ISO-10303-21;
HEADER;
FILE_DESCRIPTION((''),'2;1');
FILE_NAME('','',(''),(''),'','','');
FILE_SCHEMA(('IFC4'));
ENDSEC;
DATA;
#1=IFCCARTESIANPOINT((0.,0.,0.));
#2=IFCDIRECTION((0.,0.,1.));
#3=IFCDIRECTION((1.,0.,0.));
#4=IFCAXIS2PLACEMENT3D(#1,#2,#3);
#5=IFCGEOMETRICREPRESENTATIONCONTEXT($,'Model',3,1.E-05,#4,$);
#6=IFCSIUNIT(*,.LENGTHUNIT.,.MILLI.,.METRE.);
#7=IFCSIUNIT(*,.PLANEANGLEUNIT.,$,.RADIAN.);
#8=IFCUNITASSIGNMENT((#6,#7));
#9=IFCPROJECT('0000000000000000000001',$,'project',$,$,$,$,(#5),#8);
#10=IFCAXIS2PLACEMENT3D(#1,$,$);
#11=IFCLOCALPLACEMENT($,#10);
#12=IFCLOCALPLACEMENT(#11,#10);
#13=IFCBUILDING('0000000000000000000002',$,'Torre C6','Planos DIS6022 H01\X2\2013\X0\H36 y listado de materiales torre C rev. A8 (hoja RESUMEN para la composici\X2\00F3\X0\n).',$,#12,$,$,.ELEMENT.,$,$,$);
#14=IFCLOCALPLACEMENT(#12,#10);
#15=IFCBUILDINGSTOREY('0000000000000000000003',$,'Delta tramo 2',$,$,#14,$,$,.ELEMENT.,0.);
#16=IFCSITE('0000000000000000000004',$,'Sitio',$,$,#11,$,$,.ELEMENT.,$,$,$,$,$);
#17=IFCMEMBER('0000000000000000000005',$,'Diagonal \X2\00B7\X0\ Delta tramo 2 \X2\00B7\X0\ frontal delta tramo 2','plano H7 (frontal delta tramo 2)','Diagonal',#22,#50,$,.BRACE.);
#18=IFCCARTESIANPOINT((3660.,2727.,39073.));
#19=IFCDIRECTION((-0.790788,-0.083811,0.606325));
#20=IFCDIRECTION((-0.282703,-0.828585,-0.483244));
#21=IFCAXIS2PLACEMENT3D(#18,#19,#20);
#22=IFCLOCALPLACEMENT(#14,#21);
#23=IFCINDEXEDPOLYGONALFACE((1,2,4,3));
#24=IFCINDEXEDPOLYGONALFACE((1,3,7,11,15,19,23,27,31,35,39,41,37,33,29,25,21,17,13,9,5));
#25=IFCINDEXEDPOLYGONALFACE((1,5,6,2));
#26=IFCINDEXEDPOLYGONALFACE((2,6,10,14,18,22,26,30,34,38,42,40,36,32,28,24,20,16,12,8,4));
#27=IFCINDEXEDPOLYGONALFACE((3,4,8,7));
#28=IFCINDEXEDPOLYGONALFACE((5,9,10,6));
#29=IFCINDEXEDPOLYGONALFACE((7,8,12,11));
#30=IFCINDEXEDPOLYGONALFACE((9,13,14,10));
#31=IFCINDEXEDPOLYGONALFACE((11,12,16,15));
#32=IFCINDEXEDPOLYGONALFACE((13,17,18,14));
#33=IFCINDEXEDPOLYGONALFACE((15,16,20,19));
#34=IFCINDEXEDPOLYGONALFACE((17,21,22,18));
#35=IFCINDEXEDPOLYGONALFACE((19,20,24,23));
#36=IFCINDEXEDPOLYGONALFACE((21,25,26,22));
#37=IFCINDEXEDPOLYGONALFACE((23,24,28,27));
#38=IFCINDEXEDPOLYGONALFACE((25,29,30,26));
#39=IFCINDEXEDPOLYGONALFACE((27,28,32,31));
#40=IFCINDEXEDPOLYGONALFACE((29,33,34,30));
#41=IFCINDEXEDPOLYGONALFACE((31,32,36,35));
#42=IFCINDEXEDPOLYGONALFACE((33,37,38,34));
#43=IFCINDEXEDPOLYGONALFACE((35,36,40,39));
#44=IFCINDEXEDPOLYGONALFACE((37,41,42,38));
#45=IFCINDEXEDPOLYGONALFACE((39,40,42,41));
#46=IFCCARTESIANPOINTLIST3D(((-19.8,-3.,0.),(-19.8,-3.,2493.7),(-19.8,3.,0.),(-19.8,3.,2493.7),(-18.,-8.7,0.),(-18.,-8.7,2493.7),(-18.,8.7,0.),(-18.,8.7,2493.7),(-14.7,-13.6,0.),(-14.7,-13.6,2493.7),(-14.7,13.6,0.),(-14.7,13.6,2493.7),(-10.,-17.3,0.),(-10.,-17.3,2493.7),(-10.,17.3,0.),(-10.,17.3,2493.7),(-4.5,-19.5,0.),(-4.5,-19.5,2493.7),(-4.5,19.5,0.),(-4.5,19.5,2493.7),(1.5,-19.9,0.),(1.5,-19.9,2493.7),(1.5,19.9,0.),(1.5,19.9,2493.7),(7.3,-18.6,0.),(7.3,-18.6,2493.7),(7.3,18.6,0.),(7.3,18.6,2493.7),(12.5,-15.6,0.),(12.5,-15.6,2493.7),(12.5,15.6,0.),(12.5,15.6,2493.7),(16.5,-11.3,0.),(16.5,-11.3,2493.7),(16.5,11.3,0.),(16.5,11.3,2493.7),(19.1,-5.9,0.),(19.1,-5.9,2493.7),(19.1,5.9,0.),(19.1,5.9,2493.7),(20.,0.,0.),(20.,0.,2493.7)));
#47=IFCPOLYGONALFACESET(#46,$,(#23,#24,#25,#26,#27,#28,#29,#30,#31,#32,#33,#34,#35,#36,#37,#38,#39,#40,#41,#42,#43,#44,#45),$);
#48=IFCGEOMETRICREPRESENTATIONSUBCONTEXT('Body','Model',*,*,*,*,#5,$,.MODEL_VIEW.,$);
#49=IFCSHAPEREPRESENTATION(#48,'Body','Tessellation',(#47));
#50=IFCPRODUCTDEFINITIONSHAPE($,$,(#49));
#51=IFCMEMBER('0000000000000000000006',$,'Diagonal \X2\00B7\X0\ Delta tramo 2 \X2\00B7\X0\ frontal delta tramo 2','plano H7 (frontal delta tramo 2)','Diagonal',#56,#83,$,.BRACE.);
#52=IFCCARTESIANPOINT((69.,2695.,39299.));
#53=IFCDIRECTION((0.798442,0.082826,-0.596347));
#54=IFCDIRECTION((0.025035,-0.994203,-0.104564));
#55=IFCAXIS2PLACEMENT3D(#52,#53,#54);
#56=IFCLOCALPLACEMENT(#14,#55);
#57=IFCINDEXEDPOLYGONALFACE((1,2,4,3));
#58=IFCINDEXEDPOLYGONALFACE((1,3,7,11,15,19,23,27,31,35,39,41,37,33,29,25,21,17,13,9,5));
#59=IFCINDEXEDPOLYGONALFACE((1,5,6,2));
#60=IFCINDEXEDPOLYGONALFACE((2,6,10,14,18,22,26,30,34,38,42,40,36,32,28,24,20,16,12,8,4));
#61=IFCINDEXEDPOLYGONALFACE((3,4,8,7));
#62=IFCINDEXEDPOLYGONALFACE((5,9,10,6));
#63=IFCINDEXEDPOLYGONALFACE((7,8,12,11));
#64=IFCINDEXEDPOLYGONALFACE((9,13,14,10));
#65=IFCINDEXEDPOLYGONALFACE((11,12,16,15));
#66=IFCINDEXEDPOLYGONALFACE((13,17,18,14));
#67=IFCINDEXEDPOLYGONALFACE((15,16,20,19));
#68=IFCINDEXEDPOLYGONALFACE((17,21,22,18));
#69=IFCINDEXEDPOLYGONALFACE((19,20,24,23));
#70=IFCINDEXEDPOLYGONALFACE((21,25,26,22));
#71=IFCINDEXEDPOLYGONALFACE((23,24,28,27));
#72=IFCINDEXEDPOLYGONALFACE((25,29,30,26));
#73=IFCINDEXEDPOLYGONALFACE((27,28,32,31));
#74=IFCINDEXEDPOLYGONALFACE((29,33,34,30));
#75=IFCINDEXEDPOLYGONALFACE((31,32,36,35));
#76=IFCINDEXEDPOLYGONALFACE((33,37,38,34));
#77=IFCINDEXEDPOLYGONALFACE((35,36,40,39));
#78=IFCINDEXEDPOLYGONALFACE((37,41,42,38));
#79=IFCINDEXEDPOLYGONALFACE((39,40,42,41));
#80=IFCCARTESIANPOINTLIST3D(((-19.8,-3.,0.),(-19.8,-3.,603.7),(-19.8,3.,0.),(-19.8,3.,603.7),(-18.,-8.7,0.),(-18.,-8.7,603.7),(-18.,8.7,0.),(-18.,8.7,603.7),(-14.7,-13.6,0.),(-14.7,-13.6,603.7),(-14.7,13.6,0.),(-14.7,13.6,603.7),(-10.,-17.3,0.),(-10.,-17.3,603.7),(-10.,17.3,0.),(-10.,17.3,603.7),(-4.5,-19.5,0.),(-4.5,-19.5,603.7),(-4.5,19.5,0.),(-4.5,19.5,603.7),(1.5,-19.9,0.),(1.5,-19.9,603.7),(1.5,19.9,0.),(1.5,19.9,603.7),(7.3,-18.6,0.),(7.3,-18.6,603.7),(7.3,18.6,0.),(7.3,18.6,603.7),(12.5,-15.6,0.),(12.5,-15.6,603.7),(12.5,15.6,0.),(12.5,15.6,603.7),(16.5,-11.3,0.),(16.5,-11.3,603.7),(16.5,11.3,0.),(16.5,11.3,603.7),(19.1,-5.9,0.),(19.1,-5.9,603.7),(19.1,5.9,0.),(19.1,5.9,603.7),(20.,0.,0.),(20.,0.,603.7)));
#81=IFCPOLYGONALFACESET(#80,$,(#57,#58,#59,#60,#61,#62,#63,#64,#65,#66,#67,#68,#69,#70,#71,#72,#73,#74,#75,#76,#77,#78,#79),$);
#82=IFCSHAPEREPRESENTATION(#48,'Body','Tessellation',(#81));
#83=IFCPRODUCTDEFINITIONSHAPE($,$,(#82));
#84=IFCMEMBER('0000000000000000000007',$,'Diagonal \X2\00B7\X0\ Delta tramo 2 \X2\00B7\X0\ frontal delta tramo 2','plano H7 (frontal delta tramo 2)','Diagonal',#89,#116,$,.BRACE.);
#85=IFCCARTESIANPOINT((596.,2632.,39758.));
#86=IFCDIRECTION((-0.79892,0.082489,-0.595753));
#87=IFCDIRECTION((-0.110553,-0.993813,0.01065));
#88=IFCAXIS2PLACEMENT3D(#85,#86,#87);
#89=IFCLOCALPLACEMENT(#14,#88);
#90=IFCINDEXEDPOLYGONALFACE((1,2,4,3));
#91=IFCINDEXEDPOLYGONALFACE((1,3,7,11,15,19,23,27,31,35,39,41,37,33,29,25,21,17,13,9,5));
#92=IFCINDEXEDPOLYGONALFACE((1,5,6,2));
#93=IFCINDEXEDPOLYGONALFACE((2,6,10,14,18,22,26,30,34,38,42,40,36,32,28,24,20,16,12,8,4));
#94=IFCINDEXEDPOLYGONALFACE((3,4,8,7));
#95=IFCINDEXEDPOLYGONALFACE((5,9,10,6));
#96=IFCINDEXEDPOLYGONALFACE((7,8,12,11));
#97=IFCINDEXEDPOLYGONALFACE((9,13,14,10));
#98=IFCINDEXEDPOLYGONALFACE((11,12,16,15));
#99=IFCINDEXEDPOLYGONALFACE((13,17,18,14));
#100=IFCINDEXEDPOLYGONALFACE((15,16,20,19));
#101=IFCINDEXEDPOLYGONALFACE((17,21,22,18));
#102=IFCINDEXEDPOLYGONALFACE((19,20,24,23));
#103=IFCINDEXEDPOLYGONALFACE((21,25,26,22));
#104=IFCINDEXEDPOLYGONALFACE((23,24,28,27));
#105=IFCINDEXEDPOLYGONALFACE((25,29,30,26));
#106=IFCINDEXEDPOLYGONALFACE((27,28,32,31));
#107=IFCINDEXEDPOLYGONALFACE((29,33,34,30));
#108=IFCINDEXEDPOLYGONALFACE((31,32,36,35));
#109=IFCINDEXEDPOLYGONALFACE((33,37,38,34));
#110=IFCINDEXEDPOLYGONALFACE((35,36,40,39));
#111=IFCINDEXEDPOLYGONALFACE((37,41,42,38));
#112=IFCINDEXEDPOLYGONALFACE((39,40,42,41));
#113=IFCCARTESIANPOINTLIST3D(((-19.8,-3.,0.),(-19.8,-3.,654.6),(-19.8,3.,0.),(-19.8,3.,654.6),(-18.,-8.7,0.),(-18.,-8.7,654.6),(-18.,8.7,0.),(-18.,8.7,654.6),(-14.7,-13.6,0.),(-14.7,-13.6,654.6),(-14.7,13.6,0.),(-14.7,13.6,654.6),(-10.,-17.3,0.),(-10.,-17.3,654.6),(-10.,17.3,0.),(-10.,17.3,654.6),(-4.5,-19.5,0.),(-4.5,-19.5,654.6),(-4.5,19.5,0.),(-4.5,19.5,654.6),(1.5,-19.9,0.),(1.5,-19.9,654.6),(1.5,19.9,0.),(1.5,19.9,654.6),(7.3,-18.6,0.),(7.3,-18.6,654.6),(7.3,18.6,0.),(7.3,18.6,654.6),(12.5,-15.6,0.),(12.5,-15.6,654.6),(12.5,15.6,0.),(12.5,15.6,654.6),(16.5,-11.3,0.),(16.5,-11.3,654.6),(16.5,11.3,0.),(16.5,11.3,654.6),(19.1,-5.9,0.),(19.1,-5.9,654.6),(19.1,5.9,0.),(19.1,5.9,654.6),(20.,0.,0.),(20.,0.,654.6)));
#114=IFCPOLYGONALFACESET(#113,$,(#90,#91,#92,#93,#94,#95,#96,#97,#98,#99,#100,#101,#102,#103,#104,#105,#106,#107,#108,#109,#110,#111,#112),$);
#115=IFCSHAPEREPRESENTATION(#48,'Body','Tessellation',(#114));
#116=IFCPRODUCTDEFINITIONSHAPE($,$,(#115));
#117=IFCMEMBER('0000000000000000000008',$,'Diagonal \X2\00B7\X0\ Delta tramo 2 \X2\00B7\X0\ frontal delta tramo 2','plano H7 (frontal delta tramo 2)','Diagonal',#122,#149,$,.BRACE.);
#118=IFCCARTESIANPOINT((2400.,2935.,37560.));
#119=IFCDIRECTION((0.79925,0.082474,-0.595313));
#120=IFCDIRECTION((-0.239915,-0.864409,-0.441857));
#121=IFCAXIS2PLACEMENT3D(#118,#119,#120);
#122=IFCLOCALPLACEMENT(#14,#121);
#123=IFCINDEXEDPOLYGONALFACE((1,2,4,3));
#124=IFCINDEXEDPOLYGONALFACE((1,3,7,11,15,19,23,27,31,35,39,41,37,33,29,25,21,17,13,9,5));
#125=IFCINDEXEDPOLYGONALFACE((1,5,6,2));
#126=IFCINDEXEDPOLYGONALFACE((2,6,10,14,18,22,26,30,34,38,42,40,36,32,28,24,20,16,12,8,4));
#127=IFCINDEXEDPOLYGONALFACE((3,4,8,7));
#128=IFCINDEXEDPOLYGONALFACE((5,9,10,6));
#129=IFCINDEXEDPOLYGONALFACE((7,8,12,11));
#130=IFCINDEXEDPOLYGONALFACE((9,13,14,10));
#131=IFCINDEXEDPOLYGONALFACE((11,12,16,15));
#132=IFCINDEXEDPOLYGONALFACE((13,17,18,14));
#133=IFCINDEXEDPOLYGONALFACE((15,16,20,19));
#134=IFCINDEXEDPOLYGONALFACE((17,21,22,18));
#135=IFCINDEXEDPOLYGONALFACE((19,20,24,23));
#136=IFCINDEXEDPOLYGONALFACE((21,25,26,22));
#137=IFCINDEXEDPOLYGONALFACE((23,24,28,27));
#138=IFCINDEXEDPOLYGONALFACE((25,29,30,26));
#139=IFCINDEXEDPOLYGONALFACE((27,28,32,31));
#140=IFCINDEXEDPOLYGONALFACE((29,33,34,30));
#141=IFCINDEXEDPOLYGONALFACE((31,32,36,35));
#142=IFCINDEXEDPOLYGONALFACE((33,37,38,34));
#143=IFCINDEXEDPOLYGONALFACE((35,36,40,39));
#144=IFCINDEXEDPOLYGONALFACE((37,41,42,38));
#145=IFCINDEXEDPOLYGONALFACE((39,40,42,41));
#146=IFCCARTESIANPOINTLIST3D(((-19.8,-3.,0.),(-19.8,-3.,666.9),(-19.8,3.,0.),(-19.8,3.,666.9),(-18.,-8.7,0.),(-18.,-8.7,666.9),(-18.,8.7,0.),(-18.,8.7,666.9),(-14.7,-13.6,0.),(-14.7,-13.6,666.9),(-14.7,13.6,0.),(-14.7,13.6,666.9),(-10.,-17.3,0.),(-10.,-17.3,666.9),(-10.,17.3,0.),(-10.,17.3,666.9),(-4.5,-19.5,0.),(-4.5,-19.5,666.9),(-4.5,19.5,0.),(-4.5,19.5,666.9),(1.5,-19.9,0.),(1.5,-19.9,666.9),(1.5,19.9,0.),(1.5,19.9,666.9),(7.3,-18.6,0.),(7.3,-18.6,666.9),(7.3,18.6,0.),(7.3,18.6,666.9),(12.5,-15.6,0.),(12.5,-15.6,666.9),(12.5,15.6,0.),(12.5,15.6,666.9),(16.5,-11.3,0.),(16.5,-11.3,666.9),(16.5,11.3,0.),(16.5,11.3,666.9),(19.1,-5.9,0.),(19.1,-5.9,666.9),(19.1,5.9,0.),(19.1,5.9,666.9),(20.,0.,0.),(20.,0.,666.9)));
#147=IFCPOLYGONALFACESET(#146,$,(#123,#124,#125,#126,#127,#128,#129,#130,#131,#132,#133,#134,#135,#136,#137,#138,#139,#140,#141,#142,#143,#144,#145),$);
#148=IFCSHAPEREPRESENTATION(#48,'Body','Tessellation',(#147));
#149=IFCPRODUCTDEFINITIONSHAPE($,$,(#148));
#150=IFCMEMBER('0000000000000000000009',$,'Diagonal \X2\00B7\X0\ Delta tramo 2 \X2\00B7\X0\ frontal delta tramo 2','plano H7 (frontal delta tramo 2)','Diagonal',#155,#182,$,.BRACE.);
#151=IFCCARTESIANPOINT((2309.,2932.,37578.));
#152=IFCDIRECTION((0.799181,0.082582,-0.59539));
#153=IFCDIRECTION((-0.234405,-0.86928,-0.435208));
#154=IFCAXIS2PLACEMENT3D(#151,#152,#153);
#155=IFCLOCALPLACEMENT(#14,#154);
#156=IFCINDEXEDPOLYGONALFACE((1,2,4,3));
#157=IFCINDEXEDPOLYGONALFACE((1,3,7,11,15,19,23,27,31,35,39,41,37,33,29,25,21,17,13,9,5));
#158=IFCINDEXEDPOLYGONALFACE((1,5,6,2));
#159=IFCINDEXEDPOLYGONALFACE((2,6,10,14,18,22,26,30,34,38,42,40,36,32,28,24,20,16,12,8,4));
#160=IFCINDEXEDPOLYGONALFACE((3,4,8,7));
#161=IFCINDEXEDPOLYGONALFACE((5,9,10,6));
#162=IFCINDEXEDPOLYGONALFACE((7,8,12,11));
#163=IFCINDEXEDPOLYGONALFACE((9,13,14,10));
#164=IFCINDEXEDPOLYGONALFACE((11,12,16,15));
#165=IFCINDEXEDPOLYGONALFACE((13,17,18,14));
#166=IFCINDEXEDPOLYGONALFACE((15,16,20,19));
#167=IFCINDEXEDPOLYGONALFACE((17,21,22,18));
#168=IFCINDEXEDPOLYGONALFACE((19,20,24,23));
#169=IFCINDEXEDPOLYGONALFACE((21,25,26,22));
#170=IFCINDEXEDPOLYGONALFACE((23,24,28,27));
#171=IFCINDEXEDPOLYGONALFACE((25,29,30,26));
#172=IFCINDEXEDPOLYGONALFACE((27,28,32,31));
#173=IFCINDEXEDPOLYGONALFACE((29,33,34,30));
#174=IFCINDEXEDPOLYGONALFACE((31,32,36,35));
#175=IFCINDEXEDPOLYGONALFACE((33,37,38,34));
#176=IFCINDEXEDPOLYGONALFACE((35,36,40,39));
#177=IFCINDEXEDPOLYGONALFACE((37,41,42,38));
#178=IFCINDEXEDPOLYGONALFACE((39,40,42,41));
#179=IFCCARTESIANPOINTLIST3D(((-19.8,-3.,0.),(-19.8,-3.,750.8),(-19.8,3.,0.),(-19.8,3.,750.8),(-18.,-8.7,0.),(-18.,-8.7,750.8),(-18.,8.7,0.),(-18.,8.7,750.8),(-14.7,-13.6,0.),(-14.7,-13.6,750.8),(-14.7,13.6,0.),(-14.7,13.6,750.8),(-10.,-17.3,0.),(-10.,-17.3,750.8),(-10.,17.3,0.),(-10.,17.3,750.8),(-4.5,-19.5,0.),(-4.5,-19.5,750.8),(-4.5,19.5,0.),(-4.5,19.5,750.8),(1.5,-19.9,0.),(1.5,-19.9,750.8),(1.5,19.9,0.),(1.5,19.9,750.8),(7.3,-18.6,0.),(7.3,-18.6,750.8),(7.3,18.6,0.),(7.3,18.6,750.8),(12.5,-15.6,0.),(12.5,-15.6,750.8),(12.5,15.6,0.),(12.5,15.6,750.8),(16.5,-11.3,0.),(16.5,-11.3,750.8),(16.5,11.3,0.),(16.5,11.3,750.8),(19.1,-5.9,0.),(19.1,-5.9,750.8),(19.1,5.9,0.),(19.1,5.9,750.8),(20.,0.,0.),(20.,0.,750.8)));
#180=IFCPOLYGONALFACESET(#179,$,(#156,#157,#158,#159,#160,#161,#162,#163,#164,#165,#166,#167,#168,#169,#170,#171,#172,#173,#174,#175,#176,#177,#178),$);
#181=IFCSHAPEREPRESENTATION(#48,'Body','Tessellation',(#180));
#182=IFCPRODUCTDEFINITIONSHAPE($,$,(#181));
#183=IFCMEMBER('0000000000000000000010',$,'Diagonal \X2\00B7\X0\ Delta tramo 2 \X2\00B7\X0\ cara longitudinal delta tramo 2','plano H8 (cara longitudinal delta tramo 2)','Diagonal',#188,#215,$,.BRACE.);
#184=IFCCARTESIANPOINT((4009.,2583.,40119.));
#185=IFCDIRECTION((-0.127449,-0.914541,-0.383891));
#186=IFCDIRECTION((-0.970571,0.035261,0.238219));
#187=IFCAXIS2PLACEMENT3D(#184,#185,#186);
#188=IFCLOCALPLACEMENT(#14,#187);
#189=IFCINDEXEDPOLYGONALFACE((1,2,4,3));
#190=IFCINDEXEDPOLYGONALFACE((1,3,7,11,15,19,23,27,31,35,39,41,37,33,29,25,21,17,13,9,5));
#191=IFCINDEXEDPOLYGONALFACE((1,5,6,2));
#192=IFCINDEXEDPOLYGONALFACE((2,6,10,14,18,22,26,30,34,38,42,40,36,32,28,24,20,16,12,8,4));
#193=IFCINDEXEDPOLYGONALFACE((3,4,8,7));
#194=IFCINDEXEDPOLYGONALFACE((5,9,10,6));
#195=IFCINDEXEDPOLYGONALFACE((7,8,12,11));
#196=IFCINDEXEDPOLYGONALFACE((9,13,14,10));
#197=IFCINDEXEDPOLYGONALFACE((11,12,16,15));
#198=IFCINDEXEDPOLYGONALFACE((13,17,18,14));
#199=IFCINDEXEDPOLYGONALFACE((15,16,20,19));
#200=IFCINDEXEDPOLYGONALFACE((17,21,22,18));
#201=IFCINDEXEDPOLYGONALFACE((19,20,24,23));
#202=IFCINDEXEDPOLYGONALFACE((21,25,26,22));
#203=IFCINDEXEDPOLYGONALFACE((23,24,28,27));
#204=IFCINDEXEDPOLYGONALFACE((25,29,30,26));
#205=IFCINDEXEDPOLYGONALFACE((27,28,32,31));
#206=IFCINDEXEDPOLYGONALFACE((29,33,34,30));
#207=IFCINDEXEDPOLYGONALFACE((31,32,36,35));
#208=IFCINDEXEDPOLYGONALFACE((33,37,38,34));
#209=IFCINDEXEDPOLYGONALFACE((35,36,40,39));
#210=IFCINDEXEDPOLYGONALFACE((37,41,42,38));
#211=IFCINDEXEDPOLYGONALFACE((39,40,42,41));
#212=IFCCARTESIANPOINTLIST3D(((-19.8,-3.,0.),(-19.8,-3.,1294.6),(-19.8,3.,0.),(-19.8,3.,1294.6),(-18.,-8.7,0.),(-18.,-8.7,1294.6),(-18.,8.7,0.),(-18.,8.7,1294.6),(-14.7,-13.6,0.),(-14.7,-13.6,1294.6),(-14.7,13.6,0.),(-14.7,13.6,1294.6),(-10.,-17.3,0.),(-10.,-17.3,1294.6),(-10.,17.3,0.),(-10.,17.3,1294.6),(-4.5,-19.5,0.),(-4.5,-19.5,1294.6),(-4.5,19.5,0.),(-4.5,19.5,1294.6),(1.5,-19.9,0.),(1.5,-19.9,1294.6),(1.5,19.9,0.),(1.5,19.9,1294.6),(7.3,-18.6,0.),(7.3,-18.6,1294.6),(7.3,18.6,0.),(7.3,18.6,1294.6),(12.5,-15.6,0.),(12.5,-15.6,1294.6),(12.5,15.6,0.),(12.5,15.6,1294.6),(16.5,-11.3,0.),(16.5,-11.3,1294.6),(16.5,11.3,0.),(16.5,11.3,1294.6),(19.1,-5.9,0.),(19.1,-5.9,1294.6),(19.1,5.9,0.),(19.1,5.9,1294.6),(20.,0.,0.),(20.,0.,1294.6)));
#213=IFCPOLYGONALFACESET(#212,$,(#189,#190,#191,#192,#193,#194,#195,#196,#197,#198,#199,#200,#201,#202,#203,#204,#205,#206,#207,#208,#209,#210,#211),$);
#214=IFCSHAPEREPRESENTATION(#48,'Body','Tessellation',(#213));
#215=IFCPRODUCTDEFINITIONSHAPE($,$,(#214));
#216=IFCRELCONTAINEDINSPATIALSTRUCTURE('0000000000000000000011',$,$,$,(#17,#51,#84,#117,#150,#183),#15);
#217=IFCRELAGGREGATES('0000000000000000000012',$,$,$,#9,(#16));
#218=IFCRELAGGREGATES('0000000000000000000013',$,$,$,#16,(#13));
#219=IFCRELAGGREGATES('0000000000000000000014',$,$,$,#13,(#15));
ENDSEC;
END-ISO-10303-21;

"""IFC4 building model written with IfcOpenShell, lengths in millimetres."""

from ifc_helpers import new_model, si_unit, frame, origin, origin_with_axes, place, context, subcontext, project, spatial, circle, extrude, element, save


model = new_model("IFC4")

# Units and contexts
model_context = context("Model", 3, precision=1e-05, world=origin_with_axes())
body_context = subcontext(model_context, "Body", "Model", "MODEL_VIEW")
ifc_project = project(units=[si_unit("LENGTHUNIT", "METRE", prefix="MILLI"), si_unit("PLANEANGLEUNIT", "RADIAN")], contexts=[model_context])

# Site, building, storey
site_placement = place(None, origin())
site = spatial("IfcSite", under=ifc_project, at=site_placement, Name="Sitio", CompositionType="ELEMENT")
building_placement = place(site_placement, origin())
building = spatial("IfcBuilding", under=site, at=building_placement, Name="Torre C6", Description="Planos DIS6022 H01–H36 y listado de materiales torre C rev. A8 (hoja RESUMEN para la composición).", CompositionType="ELEMENT")
storey_placement = place(building_placement, origin())
storey = spatial("IfcBuildingStorey", under=building, at=storey_placement, Name="Delta tramo 2", CompositionType="ELEMENT", Elevation=0.0)

# Members
member_1_placement = place(storey_placement, frame((3660.0, 2727.0, 39073.0), z_axis=(-0.790788, -0.083811, 0.606325), x_axis=(-0.282703, -0.828585, -0.483244)))
element("IfcMember", 1, at=member_1_placement, inside=storey, Name="Diagonal · Delta tramo 2 · frontal delta tramo 2", Description="plano H7 (frontal delta tramo 2)", ObjectType="Diagonal", PredefinedType="BRACE", context=body_context, shape_type="SweptSolid", body=[
    extrude(circle(Radius=20.0), None, (0.0, 0.0, 1.0), 2493.7),
])
member_2_placement = place(storey_placement, frame((69.0, 2695.0, 39299.0), z_axis=(0.798442, 0.082826, -0.596347), x_axis=(0.025035, -0.994203, -0.104564)))
element("IfcMember", 2, at=member_2_placement, inside=storey, Name="Diagonal · Delta tramo 2 · frontal delta tramo 2", Description="plano H7 (frontal delta tramo 2)", ObjectType="Diagonal", PredefinedType="BRACE", context=body_context, shape_type="SweptSolid", body=[
    extrude(circle(Radius=20.0), None, (0.0, 0.0, 1.0), 603.7),
])
member_3_placement = place(storey_placement, frame((596.0, 2632.0, 39758.0), z_axis=(-0.79892, 0.082489, -0.595753), x_axis=(-0.110553, -0.993813, 0.01065)))
element("IfcMember", 3, at=member_3_placement, inside=storey, Name="Diagonal · Delta tramo 2 · frontal delta tramo 2", Description="plano H7 (frontal delta tramo 2)", ObjectType="Diagonal", PredefinedType="BRACE", context=body_context, shape_type="SweptSolid", body=[
    extrude(circle(Radius=20.0), None, (0.0, 0.0, 1.0), 654.6),
])
member_4_placement = place(storey_placement, frame((2400.0, 2935.0, 37560.0), z_axis=(0.79925, 0.082474, -0.595313), x_axis=(-0.239915, -0.864409, -0.441857)))
element("IfcMember", 4, at=member_4_placement, inside=storey, Name="Diagonal · Delta tramo 2 · frontal delta tramo 2", Description="plano H7 (frontal delta tramo 2)", ObjectType="Diagonal", PredefinedType="BRACE", context=body_context, shape_type="SweptSolid", body=[
    extrude(circle(Radius=20.0), None, (0.0, 0.0, 1.0), 666.9),
])
member_5_placement = place(storey_placement, frame((2309.0, 2932.0, 37578.0), z_axis=(0.799181, 0.082582, -0.59539), x_axis=(-0.234405, -0.86928, -0.435208)))
element("IfcMember", 5, at=member_5_placement, inside=storey, Name="Diagonal · Delta tramo 2 · frontal delta tramo 2", Description="plano H7 (frontal delta tramo 2)", ObjectType="Diagonal", PredefinedType="BRACE", context=body_context, shape_type="SweptSolid", body=[
    extrude(circle(Radius=20.0), None, (0.0, 0.0, 1.0), 750.8),
])
member_6_placement = place(storey_placement, frame((4009.0, 2583.0, 40119.0), z_axis=(-0.127449, -0.914541, -0.383891), x_axis=(-0.970571, 0.035261, 0.238219)))
element("IfcMember", 6, at=member_6_placement, inside=storey, Name="Diagonal · Delta tramo 2 · cara longitudinal delta tramo 2", Description="plano H8 (cara longitudinal delta tramo 2)", ObjectType="Diagonal", PredefinedType="BRACE", context=body_context, shape_type="SweptSolid", body=[
    extrude(circle(Radius=20.0), None, (0.0, 0.0, 1.0), 1294.6),
])

save(model, "model.ifc")
